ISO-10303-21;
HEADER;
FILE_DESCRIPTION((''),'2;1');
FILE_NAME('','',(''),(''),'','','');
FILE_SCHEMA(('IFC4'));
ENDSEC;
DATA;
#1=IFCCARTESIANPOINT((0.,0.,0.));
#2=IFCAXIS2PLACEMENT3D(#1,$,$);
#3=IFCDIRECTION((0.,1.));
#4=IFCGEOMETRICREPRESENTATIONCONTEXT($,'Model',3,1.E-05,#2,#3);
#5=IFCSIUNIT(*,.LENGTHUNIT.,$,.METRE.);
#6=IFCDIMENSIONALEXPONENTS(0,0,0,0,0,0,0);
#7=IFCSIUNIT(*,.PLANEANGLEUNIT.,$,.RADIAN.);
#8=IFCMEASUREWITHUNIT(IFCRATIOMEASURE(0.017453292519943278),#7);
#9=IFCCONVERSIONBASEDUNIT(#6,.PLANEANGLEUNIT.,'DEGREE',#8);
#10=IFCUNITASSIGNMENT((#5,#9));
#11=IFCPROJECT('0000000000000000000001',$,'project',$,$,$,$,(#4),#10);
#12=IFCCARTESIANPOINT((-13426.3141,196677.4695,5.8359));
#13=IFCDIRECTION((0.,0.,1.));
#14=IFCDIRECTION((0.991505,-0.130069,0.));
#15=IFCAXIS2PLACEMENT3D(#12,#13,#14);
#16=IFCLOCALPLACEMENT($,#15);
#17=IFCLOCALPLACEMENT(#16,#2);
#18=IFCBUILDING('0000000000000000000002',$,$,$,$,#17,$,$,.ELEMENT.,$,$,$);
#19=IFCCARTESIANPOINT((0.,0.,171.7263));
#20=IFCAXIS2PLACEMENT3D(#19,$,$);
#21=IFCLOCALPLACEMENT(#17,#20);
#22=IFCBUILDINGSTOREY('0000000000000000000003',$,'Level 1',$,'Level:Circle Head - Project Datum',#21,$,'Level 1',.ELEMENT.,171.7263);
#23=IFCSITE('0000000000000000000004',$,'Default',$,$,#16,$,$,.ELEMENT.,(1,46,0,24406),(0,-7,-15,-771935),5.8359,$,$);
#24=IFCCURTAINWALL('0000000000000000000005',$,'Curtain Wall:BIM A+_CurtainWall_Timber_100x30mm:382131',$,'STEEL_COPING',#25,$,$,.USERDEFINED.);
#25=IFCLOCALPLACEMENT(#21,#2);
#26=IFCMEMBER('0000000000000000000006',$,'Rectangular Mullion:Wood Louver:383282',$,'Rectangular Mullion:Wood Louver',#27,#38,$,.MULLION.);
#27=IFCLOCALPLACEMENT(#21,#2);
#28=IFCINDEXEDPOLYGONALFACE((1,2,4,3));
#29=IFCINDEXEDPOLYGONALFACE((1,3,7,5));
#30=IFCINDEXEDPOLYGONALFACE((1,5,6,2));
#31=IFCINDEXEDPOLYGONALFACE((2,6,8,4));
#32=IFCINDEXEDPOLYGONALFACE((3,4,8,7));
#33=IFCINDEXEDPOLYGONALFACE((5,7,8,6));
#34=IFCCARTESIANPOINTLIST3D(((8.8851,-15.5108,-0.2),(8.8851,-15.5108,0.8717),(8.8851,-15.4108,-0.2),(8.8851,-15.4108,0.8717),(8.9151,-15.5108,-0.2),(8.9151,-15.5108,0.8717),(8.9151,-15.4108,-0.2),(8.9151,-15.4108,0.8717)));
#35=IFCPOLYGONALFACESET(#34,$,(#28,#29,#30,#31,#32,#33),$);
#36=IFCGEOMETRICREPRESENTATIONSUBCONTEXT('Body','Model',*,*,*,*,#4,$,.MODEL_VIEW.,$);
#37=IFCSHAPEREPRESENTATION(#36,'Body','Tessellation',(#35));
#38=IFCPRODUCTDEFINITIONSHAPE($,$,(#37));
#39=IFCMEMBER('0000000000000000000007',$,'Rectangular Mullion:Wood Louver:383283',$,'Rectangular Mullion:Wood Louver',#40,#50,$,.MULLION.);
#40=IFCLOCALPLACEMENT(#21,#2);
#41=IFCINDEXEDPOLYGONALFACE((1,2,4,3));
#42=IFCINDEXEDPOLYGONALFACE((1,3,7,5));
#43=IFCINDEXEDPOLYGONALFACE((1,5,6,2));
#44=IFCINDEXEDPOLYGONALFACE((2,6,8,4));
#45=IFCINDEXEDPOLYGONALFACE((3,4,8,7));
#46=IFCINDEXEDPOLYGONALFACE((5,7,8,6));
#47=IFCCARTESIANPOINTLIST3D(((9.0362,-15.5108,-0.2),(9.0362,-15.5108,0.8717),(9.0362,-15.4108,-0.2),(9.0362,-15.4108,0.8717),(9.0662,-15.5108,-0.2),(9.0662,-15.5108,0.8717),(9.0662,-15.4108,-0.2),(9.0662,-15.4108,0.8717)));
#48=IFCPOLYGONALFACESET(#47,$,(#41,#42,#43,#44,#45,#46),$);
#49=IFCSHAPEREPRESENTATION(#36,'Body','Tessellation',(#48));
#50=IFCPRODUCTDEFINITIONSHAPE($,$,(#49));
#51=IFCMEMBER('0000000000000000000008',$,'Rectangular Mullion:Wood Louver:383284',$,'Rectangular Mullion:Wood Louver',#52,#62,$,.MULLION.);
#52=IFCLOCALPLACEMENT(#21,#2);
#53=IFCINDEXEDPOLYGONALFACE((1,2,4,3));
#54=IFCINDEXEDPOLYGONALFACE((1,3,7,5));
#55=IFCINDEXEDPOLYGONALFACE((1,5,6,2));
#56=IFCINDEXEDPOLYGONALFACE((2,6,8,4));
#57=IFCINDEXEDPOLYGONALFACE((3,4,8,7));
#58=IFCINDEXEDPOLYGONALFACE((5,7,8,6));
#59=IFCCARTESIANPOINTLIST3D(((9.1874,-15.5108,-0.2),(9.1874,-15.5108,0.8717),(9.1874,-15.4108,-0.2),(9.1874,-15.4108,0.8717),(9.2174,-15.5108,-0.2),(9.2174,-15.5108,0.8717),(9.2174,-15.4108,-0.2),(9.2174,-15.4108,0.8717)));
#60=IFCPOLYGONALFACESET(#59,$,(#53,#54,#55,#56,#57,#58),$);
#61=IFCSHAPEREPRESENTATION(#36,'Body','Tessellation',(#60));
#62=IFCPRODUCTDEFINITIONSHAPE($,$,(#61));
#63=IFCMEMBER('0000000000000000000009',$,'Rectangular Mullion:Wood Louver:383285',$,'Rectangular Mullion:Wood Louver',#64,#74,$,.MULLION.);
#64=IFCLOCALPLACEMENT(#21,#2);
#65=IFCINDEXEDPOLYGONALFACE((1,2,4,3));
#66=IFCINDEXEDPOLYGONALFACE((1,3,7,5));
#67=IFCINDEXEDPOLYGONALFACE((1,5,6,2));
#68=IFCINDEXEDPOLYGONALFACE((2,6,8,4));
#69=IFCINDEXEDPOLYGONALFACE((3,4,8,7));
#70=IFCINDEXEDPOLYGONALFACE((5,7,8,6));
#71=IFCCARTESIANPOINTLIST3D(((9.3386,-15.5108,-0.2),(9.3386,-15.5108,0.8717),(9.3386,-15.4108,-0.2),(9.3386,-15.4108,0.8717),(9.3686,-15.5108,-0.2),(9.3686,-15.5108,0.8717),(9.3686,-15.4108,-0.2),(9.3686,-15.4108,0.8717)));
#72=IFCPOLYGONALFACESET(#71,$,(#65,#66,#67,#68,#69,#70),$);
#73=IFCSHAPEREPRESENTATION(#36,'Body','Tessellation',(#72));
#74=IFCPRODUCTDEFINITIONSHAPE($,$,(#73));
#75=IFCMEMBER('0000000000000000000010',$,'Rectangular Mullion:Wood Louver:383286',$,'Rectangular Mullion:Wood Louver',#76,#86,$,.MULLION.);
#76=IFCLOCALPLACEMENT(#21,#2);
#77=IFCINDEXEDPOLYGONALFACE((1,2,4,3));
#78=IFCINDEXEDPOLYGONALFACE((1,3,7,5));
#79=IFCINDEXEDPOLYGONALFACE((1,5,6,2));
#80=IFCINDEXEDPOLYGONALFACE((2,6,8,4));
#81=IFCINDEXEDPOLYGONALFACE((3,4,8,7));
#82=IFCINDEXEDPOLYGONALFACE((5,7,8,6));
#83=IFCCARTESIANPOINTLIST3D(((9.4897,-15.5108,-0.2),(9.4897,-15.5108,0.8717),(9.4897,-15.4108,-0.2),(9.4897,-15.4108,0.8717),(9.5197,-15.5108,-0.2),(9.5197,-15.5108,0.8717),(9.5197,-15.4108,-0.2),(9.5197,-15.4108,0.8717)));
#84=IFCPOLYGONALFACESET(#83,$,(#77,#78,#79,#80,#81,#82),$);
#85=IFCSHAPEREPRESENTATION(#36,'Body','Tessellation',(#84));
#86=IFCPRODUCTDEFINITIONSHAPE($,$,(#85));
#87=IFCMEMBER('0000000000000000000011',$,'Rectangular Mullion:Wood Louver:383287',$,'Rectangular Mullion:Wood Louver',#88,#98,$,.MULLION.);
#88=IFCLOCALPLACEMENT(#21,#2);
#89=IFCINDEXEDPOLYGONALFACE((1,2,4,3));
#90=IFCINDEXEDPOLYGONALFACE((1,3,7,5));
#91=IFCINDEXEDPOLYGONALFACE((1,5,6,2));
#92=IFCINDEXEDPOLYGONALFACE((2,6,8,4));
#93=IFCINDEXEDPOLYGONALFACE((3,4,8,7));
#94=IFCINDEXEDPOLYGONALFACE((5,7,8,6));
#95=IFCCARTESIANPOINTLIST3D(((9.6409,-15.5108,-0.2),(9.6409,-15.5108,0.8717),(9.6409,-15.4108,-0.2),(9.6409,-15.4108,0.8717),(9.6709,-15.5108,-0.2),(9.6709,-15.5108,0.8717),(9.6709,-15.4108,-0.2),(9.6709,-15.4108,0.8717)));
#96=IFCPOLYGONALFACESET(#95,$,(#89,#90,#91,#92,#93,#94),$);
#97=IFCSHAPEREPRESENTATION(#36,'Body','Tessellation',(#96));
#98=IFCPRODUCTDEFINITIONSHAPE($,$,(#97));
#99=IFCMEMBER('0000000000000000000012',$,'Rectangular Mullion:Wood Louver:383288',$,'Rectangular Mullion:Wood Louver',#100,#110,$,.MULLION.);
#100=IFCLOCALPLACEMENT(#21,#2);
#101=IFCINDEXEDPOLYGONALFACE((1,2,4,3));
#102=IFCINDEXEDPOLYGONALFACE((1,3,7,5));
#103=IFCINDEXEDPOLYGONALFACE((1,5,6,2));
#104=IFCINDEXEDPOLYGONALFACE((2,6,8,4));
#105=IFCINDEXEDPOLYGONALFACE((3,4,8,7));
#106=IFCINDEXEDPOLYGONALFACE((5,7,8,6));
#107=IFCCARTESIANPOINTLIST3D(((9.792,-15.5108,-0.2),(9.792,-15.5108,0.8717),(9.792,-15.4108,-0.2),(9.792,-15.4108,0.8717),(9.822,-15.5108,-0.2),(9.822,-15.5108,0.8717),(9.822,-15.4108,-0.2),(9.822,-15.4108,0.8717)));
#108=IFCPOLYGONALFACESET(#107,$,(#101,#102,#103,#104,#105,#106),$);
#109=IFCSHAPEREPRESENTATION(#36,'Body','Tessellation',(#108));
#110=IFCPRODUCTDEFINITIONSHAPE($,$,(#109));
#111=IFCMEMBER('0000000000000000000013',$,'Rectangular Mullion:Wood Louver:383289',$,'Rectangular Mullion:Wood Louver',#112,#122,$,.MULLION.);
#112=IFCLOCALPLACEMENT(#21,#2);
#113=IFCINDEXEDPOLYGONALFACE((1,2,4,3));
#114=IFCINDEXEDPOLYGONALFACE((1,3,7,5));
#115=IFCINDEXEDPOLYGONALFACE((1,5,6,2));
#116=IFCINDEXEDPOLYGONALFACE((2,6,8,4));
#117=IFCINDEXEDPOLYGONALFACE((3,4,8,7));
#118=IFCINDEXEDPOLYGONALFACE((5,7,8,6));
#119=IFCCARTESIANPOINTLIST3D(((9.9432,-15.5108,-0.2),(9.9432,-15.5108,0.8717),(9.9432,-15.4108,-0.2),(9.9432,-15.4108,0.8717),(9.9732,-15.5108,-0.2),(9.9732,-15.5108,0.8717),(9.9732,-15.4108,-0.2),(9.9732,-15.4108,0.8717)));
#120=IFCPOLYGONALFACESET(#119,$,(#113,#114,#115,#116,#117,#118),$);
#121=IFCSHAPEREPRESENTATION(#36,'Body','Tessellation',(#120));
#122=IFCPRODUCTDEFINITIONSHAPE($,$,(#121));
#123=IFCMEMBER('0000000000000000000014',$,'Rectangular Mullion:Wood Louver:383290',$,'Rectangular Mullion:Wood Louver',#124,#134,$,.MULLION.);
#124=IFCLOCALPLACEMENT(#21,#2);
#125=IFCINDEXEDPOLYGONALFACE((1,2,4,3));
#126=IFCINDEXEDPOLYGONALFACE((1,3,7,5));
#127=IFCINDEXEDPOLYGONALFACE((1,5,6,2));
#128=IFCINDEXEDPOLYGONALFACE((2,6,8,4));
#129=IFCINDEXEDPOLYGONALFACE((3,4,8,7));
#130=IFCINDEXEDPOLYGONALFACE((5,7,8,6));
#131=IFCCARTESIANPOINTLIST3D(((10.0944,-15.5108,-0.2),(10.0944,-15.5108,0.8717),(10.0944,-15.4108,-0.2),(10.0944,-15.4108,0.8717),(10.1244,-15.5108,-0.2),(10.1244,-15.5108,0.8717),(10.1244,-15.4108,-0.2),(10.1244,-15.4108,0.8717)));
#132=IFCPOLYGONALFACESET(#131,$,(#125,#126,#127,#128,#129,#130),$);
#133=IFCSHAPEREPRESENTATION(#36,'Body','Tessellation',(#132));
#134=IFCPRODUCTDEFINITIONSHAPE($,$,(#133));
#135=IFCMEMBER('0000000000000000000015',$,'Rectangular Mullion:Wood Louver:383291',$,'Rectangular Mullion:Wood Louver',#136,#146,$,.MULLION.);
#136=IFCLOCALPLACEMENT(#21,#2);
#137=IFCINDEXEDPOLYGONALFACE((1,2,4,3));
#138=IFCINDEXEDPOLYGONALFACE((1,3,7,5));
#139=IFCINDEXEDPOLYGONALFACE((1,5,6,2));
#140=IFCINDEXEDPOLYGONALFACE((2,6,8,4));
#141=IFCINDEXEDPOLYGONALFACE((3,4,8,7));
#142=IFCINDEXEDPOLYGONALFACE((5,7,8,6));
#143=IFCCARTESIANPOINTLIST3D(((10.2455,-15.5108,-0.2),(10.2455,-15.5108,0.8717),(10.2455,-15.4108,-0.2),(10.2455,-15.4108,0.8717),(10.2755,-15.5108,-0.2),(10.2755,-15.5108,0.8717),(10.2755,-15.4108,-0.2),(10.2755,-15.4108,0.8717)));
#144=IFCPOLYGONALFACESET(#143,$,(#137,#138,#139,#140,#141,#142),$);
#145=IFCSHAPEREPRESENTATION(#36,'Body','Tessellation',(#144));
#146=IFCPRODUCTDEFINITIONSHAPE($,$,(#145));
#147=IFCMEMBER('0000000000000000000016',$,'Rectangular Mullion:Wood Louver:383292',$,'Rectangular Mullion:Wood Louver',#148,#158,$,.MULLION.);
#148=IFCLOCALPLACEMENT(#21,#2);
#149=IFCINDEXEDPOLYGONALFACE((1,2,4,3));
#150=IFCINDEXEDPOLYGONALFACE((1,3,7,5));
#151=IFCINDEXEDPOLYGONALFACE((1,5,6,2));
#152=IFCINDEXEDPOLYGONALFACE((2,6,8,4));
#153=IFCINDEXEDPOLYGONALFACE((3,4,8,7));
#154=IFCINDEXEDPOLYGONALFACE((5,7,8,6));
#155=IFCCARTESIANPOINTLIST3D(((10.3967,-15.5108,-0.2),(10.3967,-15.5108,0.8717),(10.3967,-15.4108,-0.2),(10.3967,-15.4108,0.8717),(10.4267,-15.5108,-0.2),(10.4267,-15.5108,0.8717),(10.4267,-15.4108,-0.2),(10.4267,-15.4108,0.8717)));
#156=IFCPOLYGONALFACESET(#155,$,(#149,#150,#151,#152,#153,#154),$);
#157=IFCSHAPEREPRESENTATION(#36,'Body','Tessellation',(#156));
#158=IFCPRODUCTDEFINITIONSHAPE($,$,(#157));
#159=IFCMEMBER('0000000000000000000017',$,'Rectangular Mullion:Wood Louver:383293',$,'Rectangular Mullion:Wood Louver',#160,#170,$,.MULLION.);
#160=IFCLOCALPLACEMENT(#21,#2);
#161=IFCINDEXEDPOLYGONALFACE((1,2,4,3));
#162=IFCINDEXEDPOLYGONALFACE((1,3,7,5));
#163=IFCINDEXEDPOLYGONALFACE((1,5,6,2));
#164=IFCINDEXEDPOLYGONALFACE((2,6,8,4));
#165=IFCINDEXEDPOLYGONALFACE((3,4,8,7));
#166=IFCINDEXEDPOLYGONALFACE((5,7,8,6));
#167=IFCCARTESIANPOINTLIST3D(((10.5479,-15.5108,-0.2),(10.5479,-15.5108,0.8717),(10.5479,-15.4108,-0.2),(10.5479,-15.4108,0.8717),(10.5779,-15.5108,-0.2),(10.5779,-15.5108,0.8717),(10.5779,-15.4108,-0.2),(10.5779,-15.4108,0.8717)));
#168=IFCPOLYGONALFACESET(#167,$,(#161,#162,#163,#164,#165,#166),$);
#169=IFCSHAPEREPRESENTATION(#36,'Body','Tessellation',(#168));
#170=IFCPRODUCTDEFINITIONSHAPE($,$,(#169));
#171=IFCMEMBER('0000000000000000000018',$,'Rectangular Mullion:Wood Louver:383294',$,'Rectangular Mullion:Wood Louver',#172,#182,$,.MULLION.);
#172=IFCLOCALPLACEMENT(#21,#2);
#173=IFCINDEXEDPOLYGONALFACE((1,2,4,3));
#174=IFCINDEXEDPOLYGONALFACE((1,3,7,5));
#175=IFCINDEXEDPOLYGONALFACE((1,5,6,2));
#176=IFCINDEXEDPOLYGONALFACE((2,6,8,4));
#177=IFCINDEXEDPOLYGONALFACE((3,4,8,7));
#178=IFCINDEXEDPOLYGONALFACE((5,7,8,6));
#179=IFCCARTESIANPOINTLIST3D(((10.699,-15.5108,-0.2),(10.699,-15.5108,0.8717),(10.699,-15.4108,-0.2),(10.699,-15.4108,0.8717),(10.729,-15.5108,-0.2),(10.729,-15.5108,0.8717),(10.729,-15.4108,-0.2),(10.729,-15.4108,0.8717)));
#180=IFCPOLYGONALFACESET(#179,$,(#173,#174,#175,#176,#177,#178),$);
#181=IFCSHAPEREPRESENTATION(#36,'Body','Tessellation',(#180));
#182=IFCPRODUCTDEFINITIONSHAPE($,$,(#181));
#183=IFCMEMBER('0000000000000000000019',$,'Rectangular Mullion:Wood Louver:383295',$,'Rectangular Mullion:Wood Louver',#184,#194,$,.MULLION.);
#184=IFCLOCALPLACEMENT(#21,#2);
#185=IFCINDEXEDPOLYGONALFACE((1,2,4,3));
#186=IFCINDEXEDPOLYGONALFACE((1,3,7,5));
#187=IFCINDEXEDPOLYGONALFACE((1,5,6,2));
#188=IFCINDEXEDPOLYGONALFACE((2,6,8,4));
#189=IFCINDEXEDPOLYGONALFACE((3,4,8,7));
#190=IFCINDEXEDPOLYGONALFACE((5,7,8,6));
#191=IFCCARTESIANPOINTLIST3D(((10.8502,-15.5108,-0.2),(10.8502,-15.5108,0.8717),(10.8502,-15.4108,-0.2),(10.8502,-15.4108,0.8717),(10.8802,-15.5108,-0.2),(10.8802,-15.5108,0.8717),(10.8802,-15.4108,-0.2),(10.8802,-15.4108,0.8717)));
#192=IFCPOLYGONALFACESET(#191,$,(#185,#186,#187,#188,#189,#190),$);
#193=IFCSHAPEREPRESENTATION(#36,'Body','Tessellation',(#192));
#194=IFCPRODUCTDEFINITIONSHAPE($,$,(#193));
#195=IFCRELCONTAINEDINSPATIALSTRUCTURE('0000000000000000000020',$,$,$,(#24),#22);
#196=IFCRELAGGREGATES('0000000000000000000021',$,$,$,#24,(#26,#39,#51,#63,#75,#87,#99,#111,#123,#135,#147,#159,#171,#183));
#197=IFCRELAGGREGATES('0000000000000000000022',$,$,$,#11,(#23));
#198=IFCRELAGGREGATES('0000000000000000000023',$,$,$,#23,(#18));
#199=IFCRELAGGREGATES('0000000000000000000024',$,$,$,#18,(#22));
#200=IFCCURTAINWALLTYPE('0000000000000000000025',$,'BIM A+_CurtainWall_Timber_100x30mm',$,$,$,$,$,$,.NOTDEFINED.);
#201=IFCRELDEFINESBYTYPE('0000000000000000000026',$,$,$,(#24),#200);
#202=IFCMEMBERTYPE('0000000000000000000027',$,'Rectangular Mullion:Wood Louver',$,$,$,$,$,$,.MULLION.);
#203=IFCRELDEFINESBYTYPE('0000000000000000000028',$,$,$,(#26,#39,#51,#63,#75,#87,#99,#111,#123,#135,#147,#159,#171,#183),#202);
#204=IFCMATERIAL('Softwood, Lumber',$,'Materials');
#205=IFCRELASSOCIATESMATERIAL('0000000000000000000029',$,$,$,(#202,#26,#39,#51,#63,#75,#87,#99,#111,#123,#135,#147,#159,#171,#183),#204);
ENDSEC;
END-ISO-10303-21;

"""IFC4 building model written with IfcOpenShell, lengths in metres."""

from ifc_helpers import new_model, entity, si_unit, converted_unit, direction, frame, origin, place, context, subcontext, project, spatial, indexed_curve, outline, extrude, source, transform, mapped, material, type_object, type_shapes, element, aggregate, save


model = new_model("IFC4")

# Units and contexts
model_context = context("Model", 3, precision=1e-05, world=origin(), true_north=direction((0.0, 1.0)))
body_context = subcontext(model_context, "Body", "Model", "MODEL_VIEW")
ifc_project = project(units=[si_unit("LENGTHUNIT", "METRE"), converted_unit("PLANEANGLEUNIT", "DEGREE", entity("IfcRatioMeasure", 0.017453292519943278), si_unit("PLANEANGLEUNIT", "RADIAN"), dimensions=[0, 0, 0, 0, 0, 0, 0])], contexts=[model_context])

# Site, building, storey
site_placement = place(None, frame((-13426.3141, 196677.4695, 5.8359), z_axis=(0.0, 0.0, 1.0), x_axis=(0.991505, -0.130069, 0.0)))
site = spatial("IfcSite", under=ifc_project, at=site_placement, Name="Default", CompositionType="ELEMENT", RefLatitude=(1, 46, 0, 24406), RefLongitude=(0, -7, -15, -771935), RefElevation=5.8359)
building_placement = place(site_placement, origin())
building = spatial("IfcBuilding", under=site, at=building_placement, CompositionType="ELEMENT")
storey_placement = place(building_placement, frame((0.0, 0.0, 171.7263)))
storey = spatial("IfcBuildingStorey", under=building, at=storey_placement, Name="Level 1", ObjectType="Level:Circle Head - Project Datum", LongName="Level 1", CompositionType="ELEMENT", Elevation=171.7263)

# Curtain wall, members
curtain_wall_type = type_object("IfcCurtainWallType", Name="BIM A+_CurtainWall_Timber_100x30mm", PredefinedType="NOTDEFINED")
curtain_wall_placement = place(storey_placement, frame((0.0, 0.0, -171.7263)))
curtain_wall = element("IfcCurtainWall", 1, at=curtain_wall_placement, inside=storey, type_object=curtain_wall_type, Name="Curtain Wall:BIM A+_CurtainWall_Timber_100x30mm:382131", ObjectType="STEEL_COPING", PredefinedType="USERDEFINED")
ifc_material_1 = material(Name="Softwood, Lumber", Category="Materials")
member_type_1 = type_object("IfcMemberType", Name="Rectangular Mullion:Wood Louver", PredefinedType="MULLION", material=ifc_material_1)
shared_shape_1 = source(origin(), body_context, "Body", "SweptSolid", [
    extrude(outline(indexed_curve([(-0.05, -0.015), (0.05, -0.015), (0.05, 0.015), (-0.05, 0.015), (-0.05, -0.015)], self_intersect=False)), frame((0.0, -0.035, -1.0717), z_axis=(0.0, 0.0, 1.0), x_axis=(0.0, -1.0, 0.0)), (0.0, 0.0, 1.0), 1.0717),
])
type_shapes(member_type_1, [shared_shape_1])
member_1_placement = place(curtain_wall_placement, frame((8.9001, -15.4958, 171.5263), z_axis=(0.0, 0.0, -1.0), x_axis=(1.0, 0.0, 0.0)))
member_1 = element("IfcMember", 2, at=member_1_placement, type_object=member_type_1, material=ifc_material_1, Name="Rectangular Mullion:Wood Louver:383282", ObjectType="Rectangular Mullion:Wood Louver", PredefinedType="MULLION", context=body_context, shape_type="MappedRepresentation", body=[
    mapped(shared_shape_1, transform((0.0, 0.0, 0.0), scale=1.0)),
])
member_2_placement = place(curtain_wall_placement, frame((9.0512, -15.4958, 171.5263), z_axis=(0.0, 0.0, -1.0), x_axis=(1.0, 0.0, 0.0)))
member_2 = element("IfcMember", 3, at=member_2_placement, type_object=member_type_1, material=ifc_material_1, Name="Rectangular Mullion:Wood Louver:383283", ObjectType="Rectangular Mullion:Wood Louver", PredefinedType="MULLION", context=body_context, shape_type="MappedRepresentation", body=[
    mapped(shared_shape_1, transform((0.0, 0.0, 0.0), scale=1.0)),
])
member_3_placement = place(curtain_wall_placement, frame((9.2024, -15.4958, 171.5263), z_axis=(0.0, 0.0, -1.0), x_axis=(1.0, 0.0, 0.0)))
member_3 = element("IfcMember", 4, at=member_3_placement, type_object=member_type_1, material=ifc_material_1, Name="Rectangular Mullion:Wood Louver:383284", ObjectType="Rectangular Mullion:Wood Louver", PredefinedType="MULLION", context=body_context, shape_type="MappedRepresentation", body=[
    mapped(shared_shape_1, transform((0.0, 0.0, 0.0), scale=1.0)),
])
member_4_placement = place(curtain_wall_placement, frame((9.3536, -15.4958, 171.5263), z_axis=(0.0, 0.0, -1.0), x_axis=(1.0, 0.0, 0.0)))
member_4 = element("IfcMember", 5, at=member_4_placement, type_object=member_type_1, material=ifc_material_1, Name="Rectangular Mullion:Wood Louver:383285", ObjectType="Rectangular Mullion:Wood Louver", PredefinedType="MULLION", context=body_context, shape_type="MappedRepresentation", body=[
    mapped(shared_shape_1, transform((0.0, 0.0, 0.0), scale=1.0)),
])
member_5_placement = place(curtain_wall_placement, frame((9.5047, -15.4958, 171.5263), z_axis=(0.0, 0.0, -1.0), x_axis=(1.0, 0.0, 0.0)))
member_5 = element("IfcMember", 6, at=member_5_placement, type_object=member_type_1, material=ifc_material_1, Name="Rectangular Mullion:Wood Louver:383286", ObjectType="Rectangular Mullion:Wood Louver", PredefinedType="MULLION", context=body_context, shape_type="MappedRepresentation", body=[
    mapped(shared_shape_1, transform((0.0, 0.0, 0.0), scale=1.0)),
])
member_6_placement = place(curtain_wall_placement, frame((9.6559, -15.4958, 171.5263), z_axis=(0.0, 0.0, -1.0), x_axis=(1.0, 0.0, 0.0)))
member_6 = element("IfcMember", 7, at=member_6_placement, type_object=member_type_1, material=ifc_material_1, Name="Rectangular Mullion:Wood Louver:383287", ObjectType="Rectangular Mullion:Wood Louver", PredefinedType="MULLION", context=body_context, shape_type="MappedRepresentation", body=[
    mapped(shared_shape_1, transform((0.0, 0.0, 0.0), scale=1.0)),
])
member_7_placement = place(curtain_wall_placement, frame((9.807, -15.4958, 171.5263), z_axis=(0.0, 0.0, -1.0), x_axis=(1.0, 0.0, 0.0)))
member_7 = element("IfcMember", 8, at=member_7_placement, type_object=member_type_1, material=ifc_material_1, Name="Rectangular Mullion:Wood Louver:383288", ObjectType="Rectangular Mullion:Wood Louver", PredefinedType="MULLION", context=body_context, shape_type="MappedRepresentation", body=[
    mapped(shared_shape_1, transform((0.0, 0.0, 0.0), scale=1.0)),
])
member_8_placement = place(curtain_wall_placement, frame((9.9582, -15.4958, 171.5263), z_axis=(0.0, 0.0, -1.0), x_axis=(1.0, 0.0, 0.0)))
member_8 = element("IfcMember", 9, at=member_8_placement, type_object=member_type_1, material=ifc_material_1, Name="Rectangular Mullion:Wood Louver:383289", ObjectType="Rectangular Mullion:Wood Louver", PredefinedType="MULLION", context=body_context, shape_type="MappedRepresentation", body=[
    mapped(shared_shape_1, transform((0.0, 0.0, 0.0), scale=1.0)),
])
member_9_placement = place(curtain_wall_placement, frame((10.1094, -15.4958, 171.5263), z_axis=(0.0, 0.0, -1.0), x_axis=(1.0, 0.0, 0.0)))
member_9 = element("IfcMember", 10, at=member_9_placement, type_object=member_type_1, material=ifc_material_1, Name="Rectangular Mullion:Wood Louver:383290", ObjectType="Rectangular Mullion:Wood Louver", PredefinedType="MULLION", context=body_context, shape_type="MappedRepresentation", body=[
    mapped(shared_shape_1, transform((0.0, 0.0, 0.0), scale=1.0)),
])
member_10_placement = place(curtain_wall_placement, frame((10.2605, -15.4958, 171.5263), z_axis=(0.0, 0.0, -1.0), x_axis=(1.0, 0.0, 0.0)))
member_10 = element("IfcMember", 11, at=member_10_placement, type_object=member_type_1, material=ifc_material_1, Name="Rectangular Mullion:Wood Louver:383291", ObjectType="Rectangular Mullion:Wood Louver", PredefinedType="MULLION", context=body_context, shape_type="MappedRepresentation", body=[
    mapped(shared_shape_1, transform((0.0, 0.0, 0.0), scale=1.0)),
])
member_11_placement = place(curtain_wall_placement, frame((10.4117, -15.4958, 171.5263), z_axis=(0.0, 0.0, -1.0), x_axis=(1.0, 0.0, 0.0)))
member_11 = element("IfcMember", 12, at=member_11_placement, type_object=member_type_1, material=ifc_material_1, Name="Rectangular Mullion:Wood Louver:383292", ObjectType="Rectangular Mullion:Wood Louver", PredefinedType="MULLION", context=body_context, shape_type="MappedRepresentation", body=[
    mapped(shared_shape_1, transform((0.0, 0.0, 0.0), scale=1.0)),
])
member_12_placement = place(curtain_wall_placement, frame((10.5629, -15.4958, 171.5263), z_axis=(0.0, 0.0, -1.0), x_axis=(1.0, 0.0, 0.0)))
member_12 = element("IfcMember", 13, at=member_12_placement, type_object=member_type_1, material=ifc_material_1, Name="Rectangular Mullion:Wood Louver:383293", ObjectType="Rectangular Mullion:Wood Louver", PredefinedType="MULLION", context=body_context, shape_type="MappedRepresentation", body=[
    mapped(shared_shape_1, transform((0.0, 0.0, 0.0), scale=1.0)),
])
member_13_placement = place(curtain_wall_placement, frame((10.714, -15.4958, 171.5263), z_axis=(0.0, 0.0, -1.0), x_axis=(1.0, 0.0, 0.0)))
member_13 = element("IfcMember", 14, at=member_13_placement, type_object=member_type_1, material=ifc_material_1, Name="Rectangular Mullion:Wood Louver:383294", ObjectType="Rectangular Mullion:Wood Louver", PredefinedType="MULLION", context=body_context, shape_type="MappedRepresentation", body=[
    mapped(shared_shape_1, transform((0.0, 0.0, 0.0), scale=1.0)),
])
member_14_placement = place(curtain_wall_placement, frame((10.8652, -15.4958, 171.5263), z_axis=(0.0, 0.0, -1.0), x_axis=(1.0, 0.0, 0.0)))
member_14 = element("IfcMember", 15, at=member_14_placement, type_object=member_type_1, material=ifc_material_1, Name="Rectangular Mullion:Wood Louver:383295", ObjectType="Rectangular Mullion:Wood Louver", PredefinedType="MULLION", context=body_context, shape_type="MappedRepresentation", body=[
    mapped(shared_shape_1, transform((0.0, 0.0, 0.0), scale=1.0)),
])
aggregate(curtain_wall, [member_1, member_2, member_3, member_4, member_5, member_6, member_7, member_8, member_9, member_10, member_11, member_12, member_13, member_14])

save(model, "model.ifc")
